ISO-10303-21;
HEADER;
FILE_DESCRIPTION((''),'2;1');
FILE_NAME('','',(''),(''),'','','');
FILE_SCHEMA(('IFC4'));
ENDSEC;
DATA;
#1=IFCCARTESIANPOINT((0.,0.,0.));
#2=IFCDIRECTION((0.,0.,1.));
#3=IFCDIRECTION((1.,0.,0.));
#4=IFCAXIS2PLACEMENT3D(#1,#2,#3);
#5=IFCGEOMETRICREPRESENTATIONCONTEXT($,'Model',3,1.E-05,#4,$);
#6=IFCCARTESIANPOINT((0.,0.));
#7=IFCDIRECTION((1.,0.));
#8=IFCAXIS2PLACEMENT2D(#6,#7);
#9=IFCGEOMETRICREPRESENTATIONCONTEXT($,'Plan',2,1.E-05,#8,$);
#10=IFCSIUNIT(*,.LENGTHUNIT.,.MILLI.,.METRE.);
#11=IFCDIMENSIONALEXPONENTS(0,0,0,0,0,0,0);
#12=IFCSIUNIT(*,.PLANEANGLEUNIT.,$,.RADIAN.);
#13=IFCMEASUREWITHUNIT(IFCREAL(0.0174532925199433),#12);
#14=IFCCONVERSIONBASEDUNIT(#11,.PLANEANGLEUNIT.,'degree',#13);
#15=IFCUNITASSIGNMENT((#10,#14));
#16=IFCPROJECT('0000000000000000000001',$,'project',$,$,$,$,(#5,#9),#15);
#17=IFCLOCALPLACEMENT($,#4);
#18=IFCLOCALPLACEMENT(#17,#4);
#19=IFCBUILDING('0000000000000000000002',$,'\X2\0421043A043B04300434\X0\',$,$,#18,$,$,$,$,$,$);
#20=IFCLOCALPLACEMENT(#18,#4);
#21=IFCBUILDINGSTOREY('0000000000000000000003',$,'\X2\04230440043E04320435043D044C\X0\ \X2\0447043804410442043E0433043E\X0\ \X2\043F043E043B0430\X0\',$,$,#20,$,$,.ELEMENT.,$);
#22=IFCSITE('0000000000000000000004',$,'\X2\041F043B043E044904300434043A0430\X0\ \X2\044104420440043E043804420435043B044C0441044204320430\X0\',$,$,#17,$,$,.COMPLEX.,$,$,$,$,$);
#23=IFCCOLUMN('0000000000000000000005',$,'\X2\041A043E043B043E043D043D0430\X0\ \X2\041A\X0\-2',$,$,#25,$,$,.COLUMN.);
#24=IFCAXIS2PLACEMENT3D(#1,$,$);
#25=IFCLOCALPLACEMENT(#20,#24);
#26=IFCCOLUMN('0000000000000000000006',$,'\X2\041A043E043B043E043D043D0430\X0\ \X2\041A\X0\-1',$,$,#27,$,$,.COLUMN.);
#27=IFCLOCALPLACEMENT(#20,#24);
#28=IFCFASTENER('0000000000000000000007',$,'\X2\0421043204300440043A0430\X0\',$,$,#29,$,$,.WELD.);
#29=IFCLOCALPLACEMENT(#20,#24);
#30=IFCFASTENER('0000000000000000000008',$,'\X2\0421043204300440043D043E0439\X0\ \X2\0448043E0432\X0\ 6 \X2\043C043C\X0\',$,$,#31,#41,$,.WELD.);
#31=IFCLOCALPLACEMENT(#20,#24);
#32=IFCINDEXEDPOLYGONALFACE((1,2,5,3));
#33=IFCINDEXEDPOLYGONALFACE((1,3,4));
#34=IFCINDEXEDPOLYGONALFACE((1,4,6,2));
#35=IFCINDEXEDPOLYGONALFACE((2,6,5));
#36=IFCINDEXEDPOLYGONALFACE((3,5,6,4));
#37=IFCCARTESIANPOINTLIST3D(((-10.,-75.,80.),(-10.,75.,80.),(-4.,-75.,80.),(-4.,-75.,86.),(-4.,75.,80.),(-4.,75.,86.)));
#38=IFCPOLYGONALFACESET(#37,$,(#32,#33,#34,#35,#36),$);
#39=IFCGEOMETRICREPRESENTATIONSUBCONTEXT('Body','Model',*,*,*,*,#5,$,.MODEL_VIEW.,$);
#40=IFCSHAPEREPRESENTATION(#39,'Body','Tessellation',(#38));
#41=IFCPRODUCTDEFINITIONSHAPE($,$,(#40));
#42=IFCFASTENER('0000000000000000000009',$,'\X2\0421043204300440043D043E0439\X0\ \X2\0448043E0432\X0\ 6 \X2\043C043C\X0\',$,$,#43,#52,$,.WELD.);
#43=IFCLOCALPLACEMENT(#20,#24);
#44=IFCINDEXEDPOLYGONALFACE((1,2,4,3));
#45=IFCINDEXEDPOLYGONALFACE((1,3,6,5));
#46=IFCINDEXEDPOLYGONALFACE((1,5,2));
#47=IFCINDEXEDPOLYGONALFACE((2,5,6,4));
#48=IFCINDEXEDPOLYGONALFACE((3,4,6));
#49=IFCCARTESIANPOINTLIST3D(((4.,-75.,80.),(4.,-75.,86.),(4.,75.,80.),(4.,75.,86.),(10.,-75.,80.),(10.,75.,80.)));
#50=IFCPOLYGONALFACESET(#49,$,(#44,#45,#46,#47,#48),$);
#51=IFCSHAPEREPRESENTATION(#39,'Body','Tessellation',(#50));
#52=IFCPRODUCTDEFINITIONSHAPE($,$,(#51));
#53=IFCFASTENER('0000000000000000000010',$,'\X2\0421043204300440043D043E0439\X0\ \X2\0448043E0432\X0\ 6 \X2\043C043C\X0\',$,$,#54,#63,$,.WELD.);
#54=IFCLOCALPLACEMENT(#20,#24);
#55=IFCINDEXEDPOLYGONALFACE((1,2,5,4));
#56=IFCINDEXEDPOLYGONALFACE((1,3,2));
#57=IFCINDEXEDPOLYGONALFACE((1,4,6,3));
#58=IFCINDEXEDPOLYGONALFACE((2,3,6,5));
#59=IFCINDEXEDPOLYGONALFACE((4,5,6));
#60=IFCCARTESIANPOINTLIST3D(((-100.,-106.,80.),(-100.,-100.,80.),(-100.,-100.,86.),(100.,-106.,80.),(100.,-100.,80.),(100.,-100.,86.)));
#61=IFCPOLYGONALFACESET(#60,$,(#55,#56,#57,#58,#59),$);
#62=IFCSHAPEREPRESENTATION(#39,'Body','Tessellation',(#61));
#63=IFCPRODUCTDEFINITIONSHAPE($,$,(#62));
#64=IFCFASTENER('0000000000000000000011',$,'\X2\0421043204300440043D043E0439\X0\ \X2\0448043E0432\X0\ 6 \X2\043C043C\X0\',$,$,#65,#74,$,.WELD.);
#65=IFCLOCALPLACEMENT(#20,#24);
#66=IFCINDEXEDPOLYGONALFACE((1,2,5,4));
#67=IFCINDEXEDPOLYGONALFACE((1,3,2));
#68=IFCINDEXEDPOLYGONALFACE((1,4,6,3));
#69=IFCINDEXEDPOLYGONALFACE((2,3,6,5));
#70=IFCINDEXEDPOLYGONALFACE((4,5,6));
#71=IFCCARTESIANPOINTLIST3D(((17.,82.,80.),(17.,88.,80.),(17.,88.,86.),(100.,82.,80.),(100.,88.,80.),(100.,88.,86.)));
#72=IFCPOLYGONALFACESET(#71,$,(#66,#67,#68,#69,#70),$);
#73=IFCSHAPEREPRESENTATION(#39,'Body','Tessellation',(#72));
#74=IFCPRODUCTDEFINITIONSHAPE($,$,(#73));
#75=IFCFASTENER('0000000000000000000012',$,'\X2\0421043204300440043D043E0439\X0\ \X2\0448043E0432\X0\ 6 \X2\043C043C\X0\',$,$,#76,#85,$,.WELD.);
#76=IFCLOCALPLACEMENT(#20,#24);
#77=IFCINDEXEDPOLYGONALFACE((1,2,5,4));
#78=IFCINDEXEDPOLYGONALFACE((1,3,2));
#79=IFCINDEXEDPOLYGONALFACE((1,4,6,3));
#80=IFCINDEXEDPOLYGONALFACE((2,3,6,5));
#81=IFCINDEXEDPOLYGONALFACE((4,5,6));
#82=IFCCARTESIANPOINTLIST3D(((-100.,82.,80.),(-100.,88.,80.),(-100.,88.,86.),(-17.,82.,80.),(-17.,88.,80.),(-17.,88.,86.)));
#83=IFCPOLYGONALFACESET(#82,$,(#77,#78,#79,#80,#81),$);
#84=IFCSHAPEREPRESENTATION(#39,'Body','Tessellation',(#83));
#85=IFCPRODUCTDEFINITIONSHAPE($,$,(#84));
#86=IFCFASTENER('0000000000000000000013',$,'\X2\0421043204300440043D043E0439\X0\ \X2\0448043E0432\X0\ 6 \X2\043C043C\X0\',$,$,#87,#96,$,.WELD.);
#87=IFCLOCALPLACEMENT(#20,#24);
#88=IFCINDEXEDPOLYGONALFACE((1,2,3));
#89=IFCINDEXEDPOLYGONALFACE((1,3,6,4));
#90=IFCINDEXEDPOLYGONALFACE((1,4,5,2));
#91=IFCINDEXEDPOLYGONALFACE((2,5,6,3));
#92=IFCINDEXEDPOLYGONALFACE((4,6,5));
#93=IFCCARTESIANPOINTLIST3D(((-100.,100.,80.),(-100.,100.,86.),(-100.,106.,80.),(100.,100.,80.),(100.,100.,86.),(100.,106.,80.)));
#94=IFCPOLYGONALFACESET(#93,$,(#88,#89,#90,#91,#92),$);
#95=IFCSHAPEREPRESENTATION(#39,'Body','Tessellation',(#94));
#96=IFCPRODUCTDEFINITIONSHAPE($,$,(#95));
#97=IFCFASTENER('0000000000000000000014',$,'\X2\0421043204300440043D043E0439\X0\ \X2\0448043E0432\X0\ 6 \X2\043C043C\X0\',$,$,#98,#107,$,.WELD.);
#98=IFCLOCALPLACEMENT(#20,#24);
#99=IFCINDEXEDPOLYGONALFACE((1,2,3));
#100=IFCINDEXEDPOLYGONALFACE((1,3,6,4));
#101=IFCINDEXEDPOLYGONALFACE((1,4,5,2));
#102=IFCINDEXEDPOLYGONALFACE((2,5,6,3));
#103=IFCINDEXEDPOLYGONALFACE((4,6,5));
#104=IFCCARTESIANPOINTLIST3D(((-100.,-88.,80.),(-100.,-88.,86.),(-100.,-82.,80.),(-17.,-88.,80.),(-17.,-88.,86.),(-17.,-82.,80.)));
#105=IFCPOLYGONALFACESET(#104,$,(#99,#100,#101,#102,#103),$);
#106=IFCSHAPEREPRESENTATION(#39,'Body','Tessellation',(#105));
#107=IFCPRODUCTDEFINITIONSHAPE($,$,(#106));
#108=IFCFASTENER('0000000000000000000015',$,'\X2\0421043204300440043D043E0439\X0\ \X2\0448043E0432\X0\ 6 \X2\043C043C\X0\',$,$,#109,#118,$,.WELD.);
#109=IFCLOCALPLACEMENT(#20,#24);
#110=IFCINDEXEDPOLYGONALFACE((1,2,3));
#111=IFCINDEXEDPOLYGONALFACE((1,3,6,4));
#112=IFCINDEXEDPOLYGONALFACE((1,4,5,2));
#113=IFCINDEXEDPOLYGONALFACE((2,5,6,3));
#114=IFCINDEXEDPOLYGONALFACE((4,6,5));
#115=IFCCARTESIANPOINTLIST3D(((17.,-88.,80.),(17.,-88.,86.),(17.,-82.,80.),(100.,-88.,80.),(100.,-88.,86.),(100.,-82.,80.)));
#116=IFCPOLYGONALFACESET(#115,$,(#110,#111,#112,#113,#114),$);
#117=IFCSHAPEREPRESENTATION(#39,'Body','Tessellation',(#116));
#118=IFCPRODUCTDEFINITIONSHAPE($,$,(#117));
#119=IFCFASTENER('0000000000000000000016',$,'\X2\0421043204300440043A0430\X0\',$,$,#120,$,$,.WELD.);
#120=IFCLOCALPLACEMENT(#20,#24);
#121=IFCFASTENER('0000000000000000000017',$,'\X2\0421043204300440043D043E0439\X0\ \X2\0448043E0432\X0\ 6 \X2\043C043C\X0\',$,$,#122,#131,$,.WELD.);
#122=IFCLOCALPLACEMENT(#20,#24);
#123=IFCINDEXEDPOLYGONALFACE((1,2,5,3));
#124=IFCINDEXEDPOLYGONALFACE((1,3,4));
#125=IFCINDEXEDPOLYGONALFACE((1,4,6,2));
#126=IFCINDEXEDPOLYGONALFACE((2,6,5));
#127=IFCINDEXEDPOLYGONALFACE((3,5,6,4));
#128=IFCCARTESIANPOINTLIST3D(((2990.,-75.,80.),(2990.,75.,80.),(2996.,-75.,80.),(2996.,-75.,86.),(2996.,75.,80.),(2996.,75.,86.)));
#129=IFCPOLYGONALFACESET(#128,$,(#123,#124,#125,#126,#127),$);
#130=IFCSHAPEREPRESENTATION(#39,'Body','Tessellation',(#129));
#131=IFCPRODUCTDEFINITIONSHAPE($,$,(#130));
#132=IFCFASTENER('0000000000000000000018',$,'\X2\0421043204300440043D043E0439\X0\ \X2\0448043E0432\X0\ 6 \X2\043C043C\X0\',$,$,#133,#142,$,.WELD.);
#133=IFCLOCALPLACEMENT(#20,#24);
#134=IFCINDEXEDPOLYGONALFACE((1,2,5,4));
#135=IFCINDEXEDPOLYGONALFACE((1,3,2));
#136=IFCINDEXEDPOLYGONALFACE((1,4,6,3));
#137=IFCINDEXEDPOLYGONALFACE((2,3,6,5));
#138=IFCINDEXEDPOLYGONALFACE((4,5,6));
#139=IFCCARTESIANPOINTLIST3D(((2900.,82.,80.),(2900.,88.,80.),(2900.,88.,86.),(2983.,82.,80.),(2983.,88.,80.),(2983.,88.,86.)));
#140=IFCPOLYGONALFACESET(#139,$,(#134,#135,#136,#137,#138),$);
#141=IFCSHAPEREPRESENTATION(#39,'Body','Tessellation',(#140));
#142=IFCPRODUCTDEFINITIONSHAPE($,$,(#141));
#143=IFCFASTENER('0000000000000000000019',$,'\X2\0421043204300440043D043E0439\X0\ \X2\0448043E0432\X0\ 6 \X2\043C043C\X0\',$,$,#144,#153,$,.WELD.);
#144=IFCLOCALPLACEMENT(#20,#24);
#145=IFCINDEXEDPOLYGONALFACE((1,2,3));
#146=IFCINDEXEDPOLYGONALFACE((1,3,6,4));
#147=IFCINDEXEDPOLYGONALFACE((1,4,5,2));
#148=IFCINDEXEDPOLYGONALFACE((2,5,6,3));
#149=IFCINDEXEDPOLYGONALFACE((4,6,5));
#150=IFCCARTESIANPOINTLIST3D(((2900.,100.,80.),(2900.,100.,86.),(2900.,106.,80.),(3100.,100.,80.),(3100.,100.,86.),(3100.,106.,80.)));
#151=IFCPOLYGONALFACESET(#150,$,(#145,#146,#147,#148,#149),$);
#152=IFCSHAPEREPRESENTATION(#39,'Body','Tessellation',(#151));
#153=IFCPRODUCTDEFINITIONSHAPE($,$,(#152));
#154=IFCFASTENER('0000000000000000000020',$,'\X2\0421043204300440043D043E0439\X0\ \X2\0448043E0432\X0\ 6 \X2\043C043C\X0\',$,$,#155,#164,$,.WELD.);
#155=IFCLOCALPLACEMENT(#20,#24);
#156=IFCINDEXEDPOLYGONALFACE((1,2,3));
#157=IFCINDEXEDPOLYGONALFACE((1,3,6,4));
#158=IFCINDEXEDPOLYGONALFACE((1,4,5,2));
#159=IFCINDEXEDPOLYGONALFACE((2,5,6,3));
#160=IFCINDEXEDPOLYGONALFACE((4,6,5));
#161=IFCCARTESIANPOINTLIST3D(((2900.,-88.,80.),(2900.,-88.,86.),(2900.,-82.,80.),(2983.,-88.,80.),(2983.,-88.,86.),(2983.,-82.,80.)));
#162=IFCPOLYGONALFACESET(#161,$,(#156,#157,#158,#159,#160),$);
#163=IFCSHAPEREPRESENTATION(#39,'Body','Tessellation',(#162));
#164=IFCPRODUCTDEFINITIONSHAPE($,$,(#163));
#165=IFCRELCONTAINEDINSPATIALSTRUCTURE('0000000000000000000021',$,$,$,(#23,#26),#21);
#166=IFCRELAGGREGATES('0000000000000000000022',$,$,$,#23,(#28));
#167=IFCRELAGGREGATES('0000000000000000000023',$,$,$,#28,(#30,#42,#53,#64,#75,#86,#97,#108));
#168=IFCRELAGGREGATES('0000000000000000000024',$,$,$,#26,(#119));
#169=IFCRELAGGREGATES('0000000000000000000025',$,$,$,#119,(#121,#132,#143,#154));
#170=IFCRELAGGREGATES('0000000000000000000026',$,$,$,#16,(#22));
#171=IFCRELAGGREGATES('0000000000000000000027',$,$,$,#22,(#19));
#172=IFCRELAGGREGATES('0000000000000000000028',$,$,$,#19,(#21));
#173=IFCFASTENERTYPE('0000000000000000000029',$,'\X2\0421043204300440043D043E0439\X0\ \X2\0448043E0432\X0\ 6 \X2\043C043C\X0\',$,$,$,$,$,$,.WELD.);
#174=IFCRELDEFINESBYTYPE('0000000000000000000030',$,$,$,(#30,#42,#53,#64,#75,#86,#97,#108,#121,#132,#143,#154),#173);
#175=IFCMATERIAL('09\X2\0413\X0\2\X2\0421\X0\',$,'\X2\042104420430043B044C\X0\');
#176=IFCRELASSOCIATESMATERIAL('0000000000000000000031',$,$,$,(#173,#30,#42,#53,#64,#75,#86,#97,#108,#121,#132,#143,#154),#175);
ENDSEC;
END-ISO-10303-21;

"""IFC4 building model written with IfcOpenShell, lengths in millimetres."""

from ifc_helpers import new_model, entity, si_unit, converted_unit, frame, origin_with_axes, origin_2d_with_axis, place, context, subcontext, project, spatial, line, indexed_curve, outline, extrude, material, material_profile, profile_set, profile_usage, type_object, element, aggregate, save


model = new_model("IFC4")

# Units and contexts
model_context = context("Model", 3, precision=1e-05, world=origin_with_axes())
plan_context = context("Plan", 2, precision=1e-05, world=origin_2d_with_axis())
body_context = subcontext(model_context, "Body", "Model", "MODEL_VIEW")
ifc_project = project(units=[si_unit("LENGTHUNIT", "METRE", prefix="MILLI"), converted_unit("PLANEANGLEUNIT", "degree", entity("IfcReal", 0.0174532925199433), si_unit("PLANEANGLEUNIT", "RADIAN"), dimensions=[0, 0, 0, 0, 0, 0, 0])], contexts=[model_context, plan_context])

# Site, building, storey
site_placement = place(None, origin_with_axes())
site = spatial("IfcSite", under=ifc_project, at=site_placement, Name="Площадка строительства", CompositionType="COMPLEX")
building_placement = place(site_placement, origin_with_axes())
building = spatial("IfcBuilding", under=site, at=building_placement, Name="Склад")
storey_placement = place(building_placement, origin_with_axes())
storey = spatial("IfcBuildingStorey", under=building, at=storey_placement, Name="Уровень чистого пола", CompositionType="ELEMENT")

# Column
column_1_placement = place(storey_placement, origin_with_axes())
column_1 = element("IfcColumn", 1, at=column_1_placement, inside=storey, Name="Колонна К-2", PredefinedType="COLUMN")

# Column
column_2_placement = place(storey_placement, origin_with_axes())
column_2 = element("IfcColumn", 2, at=column_2_placement, inside=storey, Name="Колонна К-1", PredefinedType="COLUMN")

# Shared definitions
ifc_material_1 = material(Name="09Г2С", Category="Сталь")

# Fasteners
fastener_1_placement = place(column_1_placement, origin_with_axes())
fastener_1 = element("IfcFastener", 3, at=fastener_1_placement, Name="Сварка", PredefinedType="WELD")
aggregate(column_1, [fastener_1])
ifc_material_profile_1 = material_profile(ifc_material_1, outline(indexed_curve([(0.0, 0.0), (6.0, 0.0), (0.0, 6.0)], segments=[line(2, 3), line(3, 1), line(1, 2)], self_intersect=False)))
ifc_profile_set_1 = profile_set([ifc_material_profile_1])
ifc_profile_usage_1 = profile_usage(ifc_profile_set_1, cardinal=5)
fastener_type = type_object("IfcFastenerType", Name="Сварной шов 6 мм", PredefinedType="WELD", material=ifc_profile_set_1)
fastener_2_placement = place(fastener_1_placement, frame((-4.0, -75.0, 80.0), z_axis=(0.0, 1.0, 0.0), x_axis=(-1.0, 0.0, 0.0)))
fastener_2 = element("IfcFastener", 4, at=fastener_2_placement, type_object=fastener_type, material=ifc_profile_usage_1, Name="Сварной шов 6 мм", PredefinedType="WELD", context=body_context, shape_type="SweptSolid", body=[
    extrude(outline(indexed_curve([(0.0, 0.0), (6.0, 0.0), (0.0, 6.0)], segments=[line(2, 3), line(3, 1), line(1, 2)], self_intersect=False)), origin_with_axes(), (0.0, 0.0, 1.0), 150.0),
])
ifc_profile_usage_2 = profile_usage(ifc_profile_set_1, cardinal=5)
fastener_3_placement = place(fastener_1_placement, frame((4.0, 75.0, 80.0), z_axis=(0.0, -1.0, 0.0), x_axis=(1.0, 0.0, 0.0)))
fastener_3 = element("IfcFastener", 5, at=fastener_3_placement, type_object=fastener_type, material=ifc_profile_usage_2, Name="Сварной шов 6 мм", PredefinedType="WELD", context=body_context, shape_type="SweptSolid", body=[
    extrude(outline(indexed_curve([(0.0, 0.0), (6.0, 0.0), (0.0, 6.0)], segments=[line(2, 3), line(3, 1), line(1, 2)], self_intersect=False)), origin_with_axes(), (0.0, 0.0, 1.0), 150.0),
])
ifc_profile_usage_3 = profile_usage(ifc_profile_set_1, cardinal=5)
fastener_4_placement = place(fastener_1_placement, frame((100.0, -100.0, 80.0), z_axis=(-1.0, 0.0, 0.0), x_axis=(0.0, -1.0, 0.0)))
fastener_4 = element("IfcFastener", 6, at=fastener_4_placement, type_object=fastener_type, material=ifc_profile_usage_3, Name="Сварной шов 6 мм", PredefinedType="WELD", context=body_context, shape_type="SweptSolid", body=[
    extrude(outline(indexed_curve([(0.0, 0.0), (6.0, 0.0), (0.0, 6.0)], segments=[line(2, 3), line(3, 1), line(1, 2)], self_intersect=False)), origin_with_axes(), (0.0, 0.0, 1.0), 200.0),
])
ifc_profile_usage_4 = profile_usage(ifc_profile_set_1, cardinal=5)
fastener_5_placement = place(fastener_1_placement, frame((100.0, 88.0, 80.0), z_axis=(-1.0, 0.0, 0.0), x_axis=(0.0, -1.0, 0.0)))
fastener_5 = element("IfcFastener", 7, at=fastener_5_placement, type_object=fastener_type, material=ifc_profile_usage_4, Name="Сварной шов 6 мм", PredefinedType="WELD", context=body_context, shape_type="SweptSolid", body=[
    extrude(outline(indexed_curve([(0.0, 0.0), (6.0, 0.0), (0.0, 6.0)], segments=[line(2, 3), line(3, 1), line(1, 2)], self_intersect=False)), origin_with_axes(), (0.0, 0.0, 1.0), 83.0),
])
ifc_profile_usage_5 = profile_usage(ifc_profile_set_1, cardinal=5)
fastener_6_placement = place(fastener_1_placement, frame((-17.0, 88.0, 80.0), z_axis=(-1.0, 0.0, 0.0), x_axis=(0.0, -1.0, 0.0)))
fastener_6 = element("IfcFastener", 8, at=fastener_6_placement, type_object=fastener_type, material=ifc_profile_usage_5, Name="Сварной шов 6 мм", PredefinedType="WELD", context=body_context, shape_type="SweptSolid", body=[
    extrude(outline(indexed_curve([(0.0, 0.0), (6.0, 0.0), (0.0, 6.0)], segments=[line(2, 3), line(3, 1), line(1, 2)], self_intersect=False)), origin_with_axes(), (0.0, 0.0, 1.0), 83.0),
])
ifc_profile_usage_6 = profile_usage(ifc_profile_set_1, cardinal=5)
fastener_7_placement = place(fastener_1_placement, frame((-100.0, 100.0, 80.0), z_axis=(1.0, 0.0, 0.0), x_axis=(0.0, 1.0, 0.0)))
fastener_7 = element("IfcFastener", 9, at=fastener_7_placement, type_object=fastener_type, material=ifc_profile_usage_6, Name="Сварной шов 6 мм", PredefinedType="WELD", context=body_context, shape_type="SweptSolid", body=[
    extrude(outline(indexed_curve([(0.0, 0.0), (6.0, 0.0), (0.0, 6.0)], segments=[line(2, 3), line(3, 1), line(1, 2)], self_intersect=False)), origin_with_axes(), (0.0, 0.0, 1.0), 200.0),
])
ifc_profile_usage_7 = profile_usage(ifc_profile_set_1, cardinal=5)
fastener_8_placement = place(fastener_1_placement, frame((-100.0, -88.0, 80.0), z_axis=(1.0, 0.0, 0.0), x_axis=(0.0, 1.0, 0.0)))
fastener_8 = element("IfcFastener", 10, at=fastener_8_placement, type_object=fastener_type, material=ifc_profile_usage_7, Name="Сварной шов 6 мм", PredefinedType="WELD", context=body_context, shape_type="SweptSolid", body=[
    extrude(outline(indexed_curve([(0.0, 0.0), (6.0, 0.0), (0.0, 6.0)], segments=[line(2, 3), line(3, 1), line(1, 2)], self_intersect=False)), origin_with_axes(), (0.0, 0.0, 1.0), 83.0),
])
ifc_profile_usage_8 = profile_usage(ifc_profile_set_1, cardinal=5)
fastener_9_placement = place(fastener_1_placement, frame((17.0, -88.0, 80.0), z_axis=(1.0, 0.0, 0.0), x_axis=(0.0, 1.0, 0.0)))
fastener_9 = element("IfcFastener", 11, at=fastener_9_placement, type_object=fastener_type, material=ifc_profile_usage_8, Name="Сварной шов 6 мм", PredefinedType="WELD", context=body_context, shape_type="SweptSolid", body=[
    extrude(outline(indexed_curve([(0.0, 0.0), (6.0, 0.0), (0.0, 6.0)], segments=[line(2, 3), line(3, 1), line(1, 2)], self_intersect=False)), origin_with_axes(), (0.0, 0.0, 1.0), 83.0),
])
aggregate(fastener_1, [fastener_2, fastener_3, fastener_4, fastener_5, fastener_6, fastener_7, fastener_8, fastener_9])
fastener_10_placement = place(column_2_placement, frame((3000.0, 0.0, 0.0), z_axis=(0.0, 0.0, 1.0), x_axis=(1.0, 0.0, 0.0)))
fastener_10 = element("IfcFastener", 12, at=fastener_10_placement, Name="Сварка", PredefinedType="WELD")
aggregate(column_2, [fastener_10])
ifc_profile_usage_9 = profile_usage(ifc_profile_set_1, cardinal=5)
fastener_11_placement = place(fastener_10_placement, frame((-4.0, -75.0, 80.0), z_axis=(0.0, 1.0, 0.0), x_axis=(-1.0, 0.0, 0.0)))
fastener_11 = element("IfcFastener", 13, at=fastener_11_placement, type_object=fastener_type, material=ifc_profile_usage_9, Name="Сварной шов 6 мм", PredefinedType="WELD", context=body_context, shape_type="SweptSolid", body=[
    extrude(outline(indexed_curve([(0.0, 0.0), (6.0, 0.0), (0.0, 6.0)], segments=[line(2, 3), line(3, 1), line(1, 2)], self_intersect=False)), origin_with_axes(), (0.0, 0.0, 1.0), 150.0),
])
ifc_profile_usage_10 = profile_usage(ifc_profile_set_1, cardinal=5)
fastener_12_placement = place(fastener_10_placement, frame((-17.0, 88.0, 80.0), z_axis=(-1.0, 0.0, 0.0), x_axis=(0.0, -1.0, 0.0)))
fastener_12 = element("IfcFastener", 14, at=fastener_12_placement, type_object=fastener_type, material=ifc_profile_usage_10, Name="Сварной шов 6 мм", PredefinedType="WELD", context=body_context, shape_type="SweptSolid", body=[
    extrude(outline(indexed_curve([(0.0, 0.0), (6.0, 0.0), (0.0, 6.0)], segments=[line(2, 3), line(3, 1), line(1, 2)], self_intersect=False)), origin_with_axes(), (0.0, 0.0, 1.0), 83.0),
])
ifc_profile_usage_11 = profile_usage(ifc_profile_set_1, cardinal=5)
fastener_13_placement = place(fastener_10_placement, frame((-100.0, 100.0, 80.0), z_axis=(1.0, 0.0, 0.0), x_axis=(0.0, 1.0, 0.0)))
fastener_13 = element("IfcFastener", 15, at=fastener_13_placement, type_object=fastener_type, material=ifc_profile_usage_11, Name="Сварной шов 6 мм", PredefinedType="WELD", context=body_context, shape_type="SweptSolid", body=[
    extrude(outline(indexed_curve([(0.0, 0.0), (6.0, 0.0), (0.0, 6.0)], segments=[line(2, 3), line(3, 1), line(1, 2)], self_intersect=False)), origin_with_axes(), (0.0, 0.0, 1.0), 200.0),
])
ifc_profile_usage_12 = profile_usage(ifc_profile_set_1, cardinal=5)
fastener_14_placement = place(fastener_10_placement, frame((-100.0, -88.0, 80.0), z_axis=(1.0, 0.0, 0.0), x_axis=(0.0, 1.0, 0.0)))
fastener_14 = element("IfcFastener", 16, at=fastener_14_placement, type_object=fastener_type, material=ifc_profile_usage_12, Name="Сварной шов 6 мм", PredefinedType="WELD", context=body_context, shape_type="SweptSolid", body=[
    extrude(outline(indexed_curve([(0.0, 0.0), (6.0, 0.0), (0.0, 6.0)], segments=[line(2, 3), line(3, 1), line(1, 2)], self_intersect=False)), origin_with_axes(), (0.0, 0.0, 1.0), 83.0),
])
aggregate(fastener_10, [fastener_11, fastener_12, fastener_13, fastener_14])

save(model, "model.ifc")
